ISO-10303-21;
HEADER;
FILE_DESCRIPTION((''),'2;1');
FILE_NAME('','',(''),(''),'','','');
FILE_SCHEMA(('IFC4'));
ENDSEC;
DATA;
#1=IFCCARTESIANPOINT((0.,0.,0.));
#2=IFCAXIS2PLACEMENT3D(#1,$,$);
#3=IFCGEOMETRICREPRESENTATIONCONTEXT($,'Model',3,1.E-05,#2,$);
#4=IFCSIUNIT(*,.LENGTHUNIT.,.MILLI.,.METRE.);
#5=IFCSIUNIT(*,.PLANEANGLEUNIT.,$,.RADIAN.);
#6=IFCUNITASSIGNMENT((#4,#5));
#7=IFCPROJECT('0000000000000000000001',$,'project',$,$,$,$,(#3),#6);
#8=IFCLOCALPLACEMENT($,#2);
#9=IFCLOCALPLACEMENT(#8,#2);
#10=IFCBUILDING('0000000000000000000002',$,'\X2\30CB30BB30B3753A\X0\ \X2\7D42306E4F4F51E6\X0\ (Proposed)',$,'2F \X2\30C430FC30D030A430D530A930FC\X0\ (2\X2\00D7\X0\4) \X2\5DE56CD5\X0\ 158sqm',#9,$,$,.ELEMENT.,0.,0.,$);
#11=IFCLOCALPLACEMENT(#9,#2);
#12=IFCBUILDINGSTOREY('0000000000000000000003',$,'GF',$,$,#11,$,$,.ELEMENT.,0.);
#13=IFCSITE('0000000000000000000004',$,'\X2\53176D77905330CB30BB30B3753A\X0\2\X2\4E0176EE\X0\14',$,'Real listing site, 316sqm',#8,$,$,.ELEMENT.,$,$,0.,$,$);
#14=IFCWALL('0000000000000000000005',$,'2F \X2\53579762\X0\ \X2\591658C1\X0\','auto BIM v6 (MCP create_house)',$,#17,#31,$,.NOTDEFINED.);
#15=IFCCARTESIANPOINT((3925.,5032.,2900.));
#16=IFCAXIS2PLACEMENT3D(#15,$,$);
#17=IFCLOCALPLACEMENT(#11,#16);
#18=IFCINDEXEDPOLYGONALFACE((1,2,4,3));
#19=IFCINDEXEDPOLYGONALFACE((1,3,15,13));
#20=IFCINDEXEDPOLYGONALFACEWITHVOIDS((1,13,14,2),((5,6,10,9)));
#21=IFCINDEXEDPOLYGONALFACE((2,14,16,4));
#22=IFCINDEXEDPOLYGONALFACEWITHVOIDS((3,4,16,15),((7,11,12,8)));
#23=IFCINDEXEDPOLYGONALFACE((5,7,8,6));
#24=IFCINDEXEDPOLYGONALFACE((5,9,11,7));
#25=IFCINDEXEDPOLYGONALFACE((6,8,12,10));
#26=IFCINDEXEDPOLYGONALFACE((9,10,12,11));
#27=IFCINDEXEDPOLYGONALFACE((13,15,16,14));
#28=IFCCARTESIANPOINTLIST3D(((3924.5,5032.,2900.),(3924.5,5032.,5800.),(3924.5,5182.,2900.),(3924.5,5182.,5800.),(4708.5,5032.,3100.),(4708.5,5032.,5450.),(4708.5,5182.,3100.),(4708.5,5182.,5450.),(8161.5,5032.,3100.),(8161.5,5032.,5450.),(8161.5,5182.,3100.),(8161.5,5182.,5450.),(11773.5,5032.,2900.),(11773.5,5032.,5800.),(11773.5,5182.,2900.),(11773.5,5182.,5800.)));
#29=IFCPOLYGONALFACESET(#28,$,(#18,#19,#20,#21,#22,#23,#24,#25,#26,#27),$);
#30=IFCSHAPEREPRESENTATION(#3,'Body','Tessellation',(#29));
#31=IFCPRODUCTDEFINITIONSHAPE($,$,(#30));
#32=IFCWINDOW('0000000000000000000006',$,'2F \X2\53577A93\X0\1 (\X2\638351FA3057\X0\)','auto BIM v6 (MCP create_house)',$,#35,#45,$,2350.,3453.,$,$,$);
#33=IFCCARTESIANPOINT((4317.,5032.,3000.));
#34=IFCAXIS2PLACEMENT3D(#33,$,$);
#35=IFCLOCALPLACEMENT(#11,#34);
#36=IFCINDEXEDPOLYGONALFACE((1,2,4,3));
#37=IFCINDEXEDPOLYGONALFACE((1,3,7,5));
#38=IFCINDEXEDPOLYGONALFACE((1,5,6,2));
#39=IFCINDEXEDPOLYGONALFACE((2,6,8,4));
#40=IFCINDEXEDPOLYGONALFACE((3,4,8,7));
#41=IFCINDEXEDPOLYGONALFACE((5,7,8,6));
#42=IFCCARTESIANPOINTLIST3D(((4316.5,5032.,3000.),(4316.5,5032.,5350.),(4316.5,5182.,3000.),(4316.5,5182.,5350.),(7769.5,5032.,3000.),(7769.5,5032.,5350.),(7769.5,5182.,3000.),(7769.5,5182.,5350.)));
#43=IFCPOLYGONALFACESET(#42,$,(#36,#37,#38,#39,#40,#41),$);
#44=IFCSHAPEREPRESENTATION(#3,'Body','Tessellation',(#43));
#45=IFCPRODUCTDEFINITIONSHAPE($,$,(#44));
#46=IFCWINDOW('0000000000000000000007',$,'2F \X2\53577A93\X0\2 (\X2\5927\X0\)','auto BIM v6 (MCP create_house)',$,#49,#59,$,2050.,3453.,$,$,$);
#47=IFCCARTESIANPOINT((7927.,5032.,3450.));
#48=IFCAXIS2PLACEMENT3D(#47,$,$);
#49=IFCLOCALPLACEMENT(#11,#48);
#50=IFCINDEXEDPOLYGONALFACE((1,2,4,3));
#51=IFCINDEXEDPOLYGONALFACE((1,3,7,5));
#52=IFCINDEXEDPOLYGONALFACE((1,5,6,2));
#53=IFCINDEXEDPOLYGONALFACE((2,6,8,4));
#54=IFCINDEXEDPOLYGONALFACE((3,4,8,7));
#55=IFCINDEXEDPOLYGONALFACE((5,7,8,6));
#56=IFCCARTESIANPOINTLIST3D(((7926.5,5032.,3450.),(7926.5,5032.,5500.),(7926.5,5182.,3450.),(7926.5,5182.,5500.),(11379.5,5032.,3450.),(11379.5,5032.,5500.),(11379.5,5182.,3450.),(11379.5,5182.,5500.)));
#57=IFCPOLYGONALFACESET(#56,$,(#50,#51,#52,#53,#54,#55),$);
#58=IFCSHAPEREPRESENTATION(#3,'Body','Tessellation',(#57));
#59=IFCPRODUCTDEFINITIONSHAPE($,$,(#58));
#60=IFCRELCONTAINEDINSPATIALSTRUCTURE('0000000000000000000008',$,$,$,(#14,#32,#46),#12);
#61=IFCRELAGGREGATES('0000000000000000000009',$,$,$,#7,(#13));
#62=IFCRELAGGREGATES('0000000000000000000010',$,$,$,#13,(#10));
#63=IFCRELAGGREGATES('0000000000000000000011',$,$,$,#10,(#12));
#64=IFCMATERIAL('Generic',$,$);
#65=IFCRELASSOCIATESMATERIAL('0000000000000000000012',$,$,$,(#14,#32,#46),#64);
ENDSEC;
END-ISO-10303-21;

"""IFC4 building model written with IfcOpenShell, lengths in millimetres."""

from ifc_helpers import new_model, si_unit, frame, frame_2d, origin, place, context, project, spatial, rectangle, extrude, material, element, fill, save


model = new_model("IFC4")

# Units and contexts
model_context = context("Model", 3, precision=1e-05, world=origin())
ifc_project = project(units=[si_unit("LENGTHUNIT", "METRE", prefix="MILLI"), si_unit("PLANEANGLEUNIT", "RADIAN")], contexts=[model_context])

# Site, building, storey
site_placement = place(None, origin())
site = spatial("IfcSite", under=ifc_project, at=site_placement, Name="北海道ニセコ町2丁目14", ObjectType="Real listing site, 316sqm", CompositionType="ELEMENT", RefElevation=0.0)
building_placement = place(site_placement, origin())
building = spatial("IfcBuilding", under=site, at=building_placement, Name="ニセコ町 終の住処 (Proposed)", ObjectType="2F ツーバイフォー (2×4) 工法 158sqm", CompositionType="ELEMENT", ElevationOfRefHeight=0.0, ElevationOfTerrain=0.0)
storey_placement = place(building_placement, origin())
storey = spatial("IfcBuildingStorey", under=building, at=storey_placement, Name="GF", CompositionType="ELEMENT", Elevation=0.0)

# Shared definitions
ifc_material = material(Name="Generic")

# Wall, openings, windows
wall_1_placement = place(storey_placement, frame((3925.0, 5032.0, 2900.0)))
wall_1 = element("IfcWall", 1, at=wall_1_placement, inside=storey, material=ifc_material, Name="2F 南面 外壁", Description="auto BIM v6 (MCP create_house)", PredefinedType="NOTDEFINED", context=model_context, shape_type="SweptSolid", body=[
    extrude(rectangle(XDim=7849.0, YDim=150.0, at=frame_2d((3924.0, 75.0))), frame((3925.0, 5032.0, 2900.0)), (0.0, 0.0, 1.0), 2900.0),
])
opening_1_placement = place(storey_placement, frame((4317.0, 5032.0, 3000.0)))
opening_1 = element("IfcOpeningElement", 2, at=opening_1_placement, cuts=wall_1, PredefinedType="NOTDEFINED", context=model_context, shape_type="SweptSolid", body=[
    extrude(rectangle(XDim=3453.0, YDim=150.0, at=frame_2d((1726.0, 75.0))), frame((4317.0, 5032.0, 3000.0)), (0.0, 0.0, 1.0), 2350.0),
])
opening_2_placement = place(storey_placement, frame((7927.0, 5032.0, 3450.0)))
opening_2 = element("IfcOpeningElement", 3, at=opening_2_placement, cuts=wall_1, PredefinedType="NOTDEFINED", context=model_context, shape_type="SweptSolid", body=[
    extrude(rectangle(XDim=3453.0, YDim=150.0, at=frame_2d((1726.0, 75.0))), frame((7927.0, 5032.0, 3450.0)), (0.0, 0.0, 1.0), 2050.0),
])
window_1_placement = place(storey_placement, frame((4317.0, 5032.0, 3000.0)))
window_1 = element("IfcWindow", 4, at=window_1_placement, inside=storey, material=ifc_material, Name="2F 南窓1 (掃出し)", Description="auto BIM v6 (MCP create_house)", OverallHeight=2350.0, OverallWidth=3453.0, context=model_context, shape_type="SweptSolid", body=[
    extrude(rectangle(XDim=3453.0, YDim=150.0, at=frame_2d((1726.0, 75.0))), frame((4317.0, 5032.0, 3000.0)), (0.0, 0.0, 1.0), 2350.0),
])
fill(opening_1, window_1)
window_2_placement = place(storey_placement, frame((7927.0, 5032.0, 3450.0)))
window_2 = element("IfcWindow", 5, at=window_2_placement, inside=storey, material=ifc_material, Name="2F 南窓2 (大)", Description="auto BIM v6 (MCP create_house)", OverallHeight=2050.0, OverallWidth=3453.0, context=model_context, shape_type="SweptSolid", body=[
    extrude(rectangle(XDim=3453.0, YDim=150.0, at=frame_2d((1726.0, 75.0))), frame((7927.0, 5032.0, 3450.0)), (0.0, 0.0, 1.0), 2050.0),
])
fill(opening_2, window_2)

save(model, "model.ifc")
